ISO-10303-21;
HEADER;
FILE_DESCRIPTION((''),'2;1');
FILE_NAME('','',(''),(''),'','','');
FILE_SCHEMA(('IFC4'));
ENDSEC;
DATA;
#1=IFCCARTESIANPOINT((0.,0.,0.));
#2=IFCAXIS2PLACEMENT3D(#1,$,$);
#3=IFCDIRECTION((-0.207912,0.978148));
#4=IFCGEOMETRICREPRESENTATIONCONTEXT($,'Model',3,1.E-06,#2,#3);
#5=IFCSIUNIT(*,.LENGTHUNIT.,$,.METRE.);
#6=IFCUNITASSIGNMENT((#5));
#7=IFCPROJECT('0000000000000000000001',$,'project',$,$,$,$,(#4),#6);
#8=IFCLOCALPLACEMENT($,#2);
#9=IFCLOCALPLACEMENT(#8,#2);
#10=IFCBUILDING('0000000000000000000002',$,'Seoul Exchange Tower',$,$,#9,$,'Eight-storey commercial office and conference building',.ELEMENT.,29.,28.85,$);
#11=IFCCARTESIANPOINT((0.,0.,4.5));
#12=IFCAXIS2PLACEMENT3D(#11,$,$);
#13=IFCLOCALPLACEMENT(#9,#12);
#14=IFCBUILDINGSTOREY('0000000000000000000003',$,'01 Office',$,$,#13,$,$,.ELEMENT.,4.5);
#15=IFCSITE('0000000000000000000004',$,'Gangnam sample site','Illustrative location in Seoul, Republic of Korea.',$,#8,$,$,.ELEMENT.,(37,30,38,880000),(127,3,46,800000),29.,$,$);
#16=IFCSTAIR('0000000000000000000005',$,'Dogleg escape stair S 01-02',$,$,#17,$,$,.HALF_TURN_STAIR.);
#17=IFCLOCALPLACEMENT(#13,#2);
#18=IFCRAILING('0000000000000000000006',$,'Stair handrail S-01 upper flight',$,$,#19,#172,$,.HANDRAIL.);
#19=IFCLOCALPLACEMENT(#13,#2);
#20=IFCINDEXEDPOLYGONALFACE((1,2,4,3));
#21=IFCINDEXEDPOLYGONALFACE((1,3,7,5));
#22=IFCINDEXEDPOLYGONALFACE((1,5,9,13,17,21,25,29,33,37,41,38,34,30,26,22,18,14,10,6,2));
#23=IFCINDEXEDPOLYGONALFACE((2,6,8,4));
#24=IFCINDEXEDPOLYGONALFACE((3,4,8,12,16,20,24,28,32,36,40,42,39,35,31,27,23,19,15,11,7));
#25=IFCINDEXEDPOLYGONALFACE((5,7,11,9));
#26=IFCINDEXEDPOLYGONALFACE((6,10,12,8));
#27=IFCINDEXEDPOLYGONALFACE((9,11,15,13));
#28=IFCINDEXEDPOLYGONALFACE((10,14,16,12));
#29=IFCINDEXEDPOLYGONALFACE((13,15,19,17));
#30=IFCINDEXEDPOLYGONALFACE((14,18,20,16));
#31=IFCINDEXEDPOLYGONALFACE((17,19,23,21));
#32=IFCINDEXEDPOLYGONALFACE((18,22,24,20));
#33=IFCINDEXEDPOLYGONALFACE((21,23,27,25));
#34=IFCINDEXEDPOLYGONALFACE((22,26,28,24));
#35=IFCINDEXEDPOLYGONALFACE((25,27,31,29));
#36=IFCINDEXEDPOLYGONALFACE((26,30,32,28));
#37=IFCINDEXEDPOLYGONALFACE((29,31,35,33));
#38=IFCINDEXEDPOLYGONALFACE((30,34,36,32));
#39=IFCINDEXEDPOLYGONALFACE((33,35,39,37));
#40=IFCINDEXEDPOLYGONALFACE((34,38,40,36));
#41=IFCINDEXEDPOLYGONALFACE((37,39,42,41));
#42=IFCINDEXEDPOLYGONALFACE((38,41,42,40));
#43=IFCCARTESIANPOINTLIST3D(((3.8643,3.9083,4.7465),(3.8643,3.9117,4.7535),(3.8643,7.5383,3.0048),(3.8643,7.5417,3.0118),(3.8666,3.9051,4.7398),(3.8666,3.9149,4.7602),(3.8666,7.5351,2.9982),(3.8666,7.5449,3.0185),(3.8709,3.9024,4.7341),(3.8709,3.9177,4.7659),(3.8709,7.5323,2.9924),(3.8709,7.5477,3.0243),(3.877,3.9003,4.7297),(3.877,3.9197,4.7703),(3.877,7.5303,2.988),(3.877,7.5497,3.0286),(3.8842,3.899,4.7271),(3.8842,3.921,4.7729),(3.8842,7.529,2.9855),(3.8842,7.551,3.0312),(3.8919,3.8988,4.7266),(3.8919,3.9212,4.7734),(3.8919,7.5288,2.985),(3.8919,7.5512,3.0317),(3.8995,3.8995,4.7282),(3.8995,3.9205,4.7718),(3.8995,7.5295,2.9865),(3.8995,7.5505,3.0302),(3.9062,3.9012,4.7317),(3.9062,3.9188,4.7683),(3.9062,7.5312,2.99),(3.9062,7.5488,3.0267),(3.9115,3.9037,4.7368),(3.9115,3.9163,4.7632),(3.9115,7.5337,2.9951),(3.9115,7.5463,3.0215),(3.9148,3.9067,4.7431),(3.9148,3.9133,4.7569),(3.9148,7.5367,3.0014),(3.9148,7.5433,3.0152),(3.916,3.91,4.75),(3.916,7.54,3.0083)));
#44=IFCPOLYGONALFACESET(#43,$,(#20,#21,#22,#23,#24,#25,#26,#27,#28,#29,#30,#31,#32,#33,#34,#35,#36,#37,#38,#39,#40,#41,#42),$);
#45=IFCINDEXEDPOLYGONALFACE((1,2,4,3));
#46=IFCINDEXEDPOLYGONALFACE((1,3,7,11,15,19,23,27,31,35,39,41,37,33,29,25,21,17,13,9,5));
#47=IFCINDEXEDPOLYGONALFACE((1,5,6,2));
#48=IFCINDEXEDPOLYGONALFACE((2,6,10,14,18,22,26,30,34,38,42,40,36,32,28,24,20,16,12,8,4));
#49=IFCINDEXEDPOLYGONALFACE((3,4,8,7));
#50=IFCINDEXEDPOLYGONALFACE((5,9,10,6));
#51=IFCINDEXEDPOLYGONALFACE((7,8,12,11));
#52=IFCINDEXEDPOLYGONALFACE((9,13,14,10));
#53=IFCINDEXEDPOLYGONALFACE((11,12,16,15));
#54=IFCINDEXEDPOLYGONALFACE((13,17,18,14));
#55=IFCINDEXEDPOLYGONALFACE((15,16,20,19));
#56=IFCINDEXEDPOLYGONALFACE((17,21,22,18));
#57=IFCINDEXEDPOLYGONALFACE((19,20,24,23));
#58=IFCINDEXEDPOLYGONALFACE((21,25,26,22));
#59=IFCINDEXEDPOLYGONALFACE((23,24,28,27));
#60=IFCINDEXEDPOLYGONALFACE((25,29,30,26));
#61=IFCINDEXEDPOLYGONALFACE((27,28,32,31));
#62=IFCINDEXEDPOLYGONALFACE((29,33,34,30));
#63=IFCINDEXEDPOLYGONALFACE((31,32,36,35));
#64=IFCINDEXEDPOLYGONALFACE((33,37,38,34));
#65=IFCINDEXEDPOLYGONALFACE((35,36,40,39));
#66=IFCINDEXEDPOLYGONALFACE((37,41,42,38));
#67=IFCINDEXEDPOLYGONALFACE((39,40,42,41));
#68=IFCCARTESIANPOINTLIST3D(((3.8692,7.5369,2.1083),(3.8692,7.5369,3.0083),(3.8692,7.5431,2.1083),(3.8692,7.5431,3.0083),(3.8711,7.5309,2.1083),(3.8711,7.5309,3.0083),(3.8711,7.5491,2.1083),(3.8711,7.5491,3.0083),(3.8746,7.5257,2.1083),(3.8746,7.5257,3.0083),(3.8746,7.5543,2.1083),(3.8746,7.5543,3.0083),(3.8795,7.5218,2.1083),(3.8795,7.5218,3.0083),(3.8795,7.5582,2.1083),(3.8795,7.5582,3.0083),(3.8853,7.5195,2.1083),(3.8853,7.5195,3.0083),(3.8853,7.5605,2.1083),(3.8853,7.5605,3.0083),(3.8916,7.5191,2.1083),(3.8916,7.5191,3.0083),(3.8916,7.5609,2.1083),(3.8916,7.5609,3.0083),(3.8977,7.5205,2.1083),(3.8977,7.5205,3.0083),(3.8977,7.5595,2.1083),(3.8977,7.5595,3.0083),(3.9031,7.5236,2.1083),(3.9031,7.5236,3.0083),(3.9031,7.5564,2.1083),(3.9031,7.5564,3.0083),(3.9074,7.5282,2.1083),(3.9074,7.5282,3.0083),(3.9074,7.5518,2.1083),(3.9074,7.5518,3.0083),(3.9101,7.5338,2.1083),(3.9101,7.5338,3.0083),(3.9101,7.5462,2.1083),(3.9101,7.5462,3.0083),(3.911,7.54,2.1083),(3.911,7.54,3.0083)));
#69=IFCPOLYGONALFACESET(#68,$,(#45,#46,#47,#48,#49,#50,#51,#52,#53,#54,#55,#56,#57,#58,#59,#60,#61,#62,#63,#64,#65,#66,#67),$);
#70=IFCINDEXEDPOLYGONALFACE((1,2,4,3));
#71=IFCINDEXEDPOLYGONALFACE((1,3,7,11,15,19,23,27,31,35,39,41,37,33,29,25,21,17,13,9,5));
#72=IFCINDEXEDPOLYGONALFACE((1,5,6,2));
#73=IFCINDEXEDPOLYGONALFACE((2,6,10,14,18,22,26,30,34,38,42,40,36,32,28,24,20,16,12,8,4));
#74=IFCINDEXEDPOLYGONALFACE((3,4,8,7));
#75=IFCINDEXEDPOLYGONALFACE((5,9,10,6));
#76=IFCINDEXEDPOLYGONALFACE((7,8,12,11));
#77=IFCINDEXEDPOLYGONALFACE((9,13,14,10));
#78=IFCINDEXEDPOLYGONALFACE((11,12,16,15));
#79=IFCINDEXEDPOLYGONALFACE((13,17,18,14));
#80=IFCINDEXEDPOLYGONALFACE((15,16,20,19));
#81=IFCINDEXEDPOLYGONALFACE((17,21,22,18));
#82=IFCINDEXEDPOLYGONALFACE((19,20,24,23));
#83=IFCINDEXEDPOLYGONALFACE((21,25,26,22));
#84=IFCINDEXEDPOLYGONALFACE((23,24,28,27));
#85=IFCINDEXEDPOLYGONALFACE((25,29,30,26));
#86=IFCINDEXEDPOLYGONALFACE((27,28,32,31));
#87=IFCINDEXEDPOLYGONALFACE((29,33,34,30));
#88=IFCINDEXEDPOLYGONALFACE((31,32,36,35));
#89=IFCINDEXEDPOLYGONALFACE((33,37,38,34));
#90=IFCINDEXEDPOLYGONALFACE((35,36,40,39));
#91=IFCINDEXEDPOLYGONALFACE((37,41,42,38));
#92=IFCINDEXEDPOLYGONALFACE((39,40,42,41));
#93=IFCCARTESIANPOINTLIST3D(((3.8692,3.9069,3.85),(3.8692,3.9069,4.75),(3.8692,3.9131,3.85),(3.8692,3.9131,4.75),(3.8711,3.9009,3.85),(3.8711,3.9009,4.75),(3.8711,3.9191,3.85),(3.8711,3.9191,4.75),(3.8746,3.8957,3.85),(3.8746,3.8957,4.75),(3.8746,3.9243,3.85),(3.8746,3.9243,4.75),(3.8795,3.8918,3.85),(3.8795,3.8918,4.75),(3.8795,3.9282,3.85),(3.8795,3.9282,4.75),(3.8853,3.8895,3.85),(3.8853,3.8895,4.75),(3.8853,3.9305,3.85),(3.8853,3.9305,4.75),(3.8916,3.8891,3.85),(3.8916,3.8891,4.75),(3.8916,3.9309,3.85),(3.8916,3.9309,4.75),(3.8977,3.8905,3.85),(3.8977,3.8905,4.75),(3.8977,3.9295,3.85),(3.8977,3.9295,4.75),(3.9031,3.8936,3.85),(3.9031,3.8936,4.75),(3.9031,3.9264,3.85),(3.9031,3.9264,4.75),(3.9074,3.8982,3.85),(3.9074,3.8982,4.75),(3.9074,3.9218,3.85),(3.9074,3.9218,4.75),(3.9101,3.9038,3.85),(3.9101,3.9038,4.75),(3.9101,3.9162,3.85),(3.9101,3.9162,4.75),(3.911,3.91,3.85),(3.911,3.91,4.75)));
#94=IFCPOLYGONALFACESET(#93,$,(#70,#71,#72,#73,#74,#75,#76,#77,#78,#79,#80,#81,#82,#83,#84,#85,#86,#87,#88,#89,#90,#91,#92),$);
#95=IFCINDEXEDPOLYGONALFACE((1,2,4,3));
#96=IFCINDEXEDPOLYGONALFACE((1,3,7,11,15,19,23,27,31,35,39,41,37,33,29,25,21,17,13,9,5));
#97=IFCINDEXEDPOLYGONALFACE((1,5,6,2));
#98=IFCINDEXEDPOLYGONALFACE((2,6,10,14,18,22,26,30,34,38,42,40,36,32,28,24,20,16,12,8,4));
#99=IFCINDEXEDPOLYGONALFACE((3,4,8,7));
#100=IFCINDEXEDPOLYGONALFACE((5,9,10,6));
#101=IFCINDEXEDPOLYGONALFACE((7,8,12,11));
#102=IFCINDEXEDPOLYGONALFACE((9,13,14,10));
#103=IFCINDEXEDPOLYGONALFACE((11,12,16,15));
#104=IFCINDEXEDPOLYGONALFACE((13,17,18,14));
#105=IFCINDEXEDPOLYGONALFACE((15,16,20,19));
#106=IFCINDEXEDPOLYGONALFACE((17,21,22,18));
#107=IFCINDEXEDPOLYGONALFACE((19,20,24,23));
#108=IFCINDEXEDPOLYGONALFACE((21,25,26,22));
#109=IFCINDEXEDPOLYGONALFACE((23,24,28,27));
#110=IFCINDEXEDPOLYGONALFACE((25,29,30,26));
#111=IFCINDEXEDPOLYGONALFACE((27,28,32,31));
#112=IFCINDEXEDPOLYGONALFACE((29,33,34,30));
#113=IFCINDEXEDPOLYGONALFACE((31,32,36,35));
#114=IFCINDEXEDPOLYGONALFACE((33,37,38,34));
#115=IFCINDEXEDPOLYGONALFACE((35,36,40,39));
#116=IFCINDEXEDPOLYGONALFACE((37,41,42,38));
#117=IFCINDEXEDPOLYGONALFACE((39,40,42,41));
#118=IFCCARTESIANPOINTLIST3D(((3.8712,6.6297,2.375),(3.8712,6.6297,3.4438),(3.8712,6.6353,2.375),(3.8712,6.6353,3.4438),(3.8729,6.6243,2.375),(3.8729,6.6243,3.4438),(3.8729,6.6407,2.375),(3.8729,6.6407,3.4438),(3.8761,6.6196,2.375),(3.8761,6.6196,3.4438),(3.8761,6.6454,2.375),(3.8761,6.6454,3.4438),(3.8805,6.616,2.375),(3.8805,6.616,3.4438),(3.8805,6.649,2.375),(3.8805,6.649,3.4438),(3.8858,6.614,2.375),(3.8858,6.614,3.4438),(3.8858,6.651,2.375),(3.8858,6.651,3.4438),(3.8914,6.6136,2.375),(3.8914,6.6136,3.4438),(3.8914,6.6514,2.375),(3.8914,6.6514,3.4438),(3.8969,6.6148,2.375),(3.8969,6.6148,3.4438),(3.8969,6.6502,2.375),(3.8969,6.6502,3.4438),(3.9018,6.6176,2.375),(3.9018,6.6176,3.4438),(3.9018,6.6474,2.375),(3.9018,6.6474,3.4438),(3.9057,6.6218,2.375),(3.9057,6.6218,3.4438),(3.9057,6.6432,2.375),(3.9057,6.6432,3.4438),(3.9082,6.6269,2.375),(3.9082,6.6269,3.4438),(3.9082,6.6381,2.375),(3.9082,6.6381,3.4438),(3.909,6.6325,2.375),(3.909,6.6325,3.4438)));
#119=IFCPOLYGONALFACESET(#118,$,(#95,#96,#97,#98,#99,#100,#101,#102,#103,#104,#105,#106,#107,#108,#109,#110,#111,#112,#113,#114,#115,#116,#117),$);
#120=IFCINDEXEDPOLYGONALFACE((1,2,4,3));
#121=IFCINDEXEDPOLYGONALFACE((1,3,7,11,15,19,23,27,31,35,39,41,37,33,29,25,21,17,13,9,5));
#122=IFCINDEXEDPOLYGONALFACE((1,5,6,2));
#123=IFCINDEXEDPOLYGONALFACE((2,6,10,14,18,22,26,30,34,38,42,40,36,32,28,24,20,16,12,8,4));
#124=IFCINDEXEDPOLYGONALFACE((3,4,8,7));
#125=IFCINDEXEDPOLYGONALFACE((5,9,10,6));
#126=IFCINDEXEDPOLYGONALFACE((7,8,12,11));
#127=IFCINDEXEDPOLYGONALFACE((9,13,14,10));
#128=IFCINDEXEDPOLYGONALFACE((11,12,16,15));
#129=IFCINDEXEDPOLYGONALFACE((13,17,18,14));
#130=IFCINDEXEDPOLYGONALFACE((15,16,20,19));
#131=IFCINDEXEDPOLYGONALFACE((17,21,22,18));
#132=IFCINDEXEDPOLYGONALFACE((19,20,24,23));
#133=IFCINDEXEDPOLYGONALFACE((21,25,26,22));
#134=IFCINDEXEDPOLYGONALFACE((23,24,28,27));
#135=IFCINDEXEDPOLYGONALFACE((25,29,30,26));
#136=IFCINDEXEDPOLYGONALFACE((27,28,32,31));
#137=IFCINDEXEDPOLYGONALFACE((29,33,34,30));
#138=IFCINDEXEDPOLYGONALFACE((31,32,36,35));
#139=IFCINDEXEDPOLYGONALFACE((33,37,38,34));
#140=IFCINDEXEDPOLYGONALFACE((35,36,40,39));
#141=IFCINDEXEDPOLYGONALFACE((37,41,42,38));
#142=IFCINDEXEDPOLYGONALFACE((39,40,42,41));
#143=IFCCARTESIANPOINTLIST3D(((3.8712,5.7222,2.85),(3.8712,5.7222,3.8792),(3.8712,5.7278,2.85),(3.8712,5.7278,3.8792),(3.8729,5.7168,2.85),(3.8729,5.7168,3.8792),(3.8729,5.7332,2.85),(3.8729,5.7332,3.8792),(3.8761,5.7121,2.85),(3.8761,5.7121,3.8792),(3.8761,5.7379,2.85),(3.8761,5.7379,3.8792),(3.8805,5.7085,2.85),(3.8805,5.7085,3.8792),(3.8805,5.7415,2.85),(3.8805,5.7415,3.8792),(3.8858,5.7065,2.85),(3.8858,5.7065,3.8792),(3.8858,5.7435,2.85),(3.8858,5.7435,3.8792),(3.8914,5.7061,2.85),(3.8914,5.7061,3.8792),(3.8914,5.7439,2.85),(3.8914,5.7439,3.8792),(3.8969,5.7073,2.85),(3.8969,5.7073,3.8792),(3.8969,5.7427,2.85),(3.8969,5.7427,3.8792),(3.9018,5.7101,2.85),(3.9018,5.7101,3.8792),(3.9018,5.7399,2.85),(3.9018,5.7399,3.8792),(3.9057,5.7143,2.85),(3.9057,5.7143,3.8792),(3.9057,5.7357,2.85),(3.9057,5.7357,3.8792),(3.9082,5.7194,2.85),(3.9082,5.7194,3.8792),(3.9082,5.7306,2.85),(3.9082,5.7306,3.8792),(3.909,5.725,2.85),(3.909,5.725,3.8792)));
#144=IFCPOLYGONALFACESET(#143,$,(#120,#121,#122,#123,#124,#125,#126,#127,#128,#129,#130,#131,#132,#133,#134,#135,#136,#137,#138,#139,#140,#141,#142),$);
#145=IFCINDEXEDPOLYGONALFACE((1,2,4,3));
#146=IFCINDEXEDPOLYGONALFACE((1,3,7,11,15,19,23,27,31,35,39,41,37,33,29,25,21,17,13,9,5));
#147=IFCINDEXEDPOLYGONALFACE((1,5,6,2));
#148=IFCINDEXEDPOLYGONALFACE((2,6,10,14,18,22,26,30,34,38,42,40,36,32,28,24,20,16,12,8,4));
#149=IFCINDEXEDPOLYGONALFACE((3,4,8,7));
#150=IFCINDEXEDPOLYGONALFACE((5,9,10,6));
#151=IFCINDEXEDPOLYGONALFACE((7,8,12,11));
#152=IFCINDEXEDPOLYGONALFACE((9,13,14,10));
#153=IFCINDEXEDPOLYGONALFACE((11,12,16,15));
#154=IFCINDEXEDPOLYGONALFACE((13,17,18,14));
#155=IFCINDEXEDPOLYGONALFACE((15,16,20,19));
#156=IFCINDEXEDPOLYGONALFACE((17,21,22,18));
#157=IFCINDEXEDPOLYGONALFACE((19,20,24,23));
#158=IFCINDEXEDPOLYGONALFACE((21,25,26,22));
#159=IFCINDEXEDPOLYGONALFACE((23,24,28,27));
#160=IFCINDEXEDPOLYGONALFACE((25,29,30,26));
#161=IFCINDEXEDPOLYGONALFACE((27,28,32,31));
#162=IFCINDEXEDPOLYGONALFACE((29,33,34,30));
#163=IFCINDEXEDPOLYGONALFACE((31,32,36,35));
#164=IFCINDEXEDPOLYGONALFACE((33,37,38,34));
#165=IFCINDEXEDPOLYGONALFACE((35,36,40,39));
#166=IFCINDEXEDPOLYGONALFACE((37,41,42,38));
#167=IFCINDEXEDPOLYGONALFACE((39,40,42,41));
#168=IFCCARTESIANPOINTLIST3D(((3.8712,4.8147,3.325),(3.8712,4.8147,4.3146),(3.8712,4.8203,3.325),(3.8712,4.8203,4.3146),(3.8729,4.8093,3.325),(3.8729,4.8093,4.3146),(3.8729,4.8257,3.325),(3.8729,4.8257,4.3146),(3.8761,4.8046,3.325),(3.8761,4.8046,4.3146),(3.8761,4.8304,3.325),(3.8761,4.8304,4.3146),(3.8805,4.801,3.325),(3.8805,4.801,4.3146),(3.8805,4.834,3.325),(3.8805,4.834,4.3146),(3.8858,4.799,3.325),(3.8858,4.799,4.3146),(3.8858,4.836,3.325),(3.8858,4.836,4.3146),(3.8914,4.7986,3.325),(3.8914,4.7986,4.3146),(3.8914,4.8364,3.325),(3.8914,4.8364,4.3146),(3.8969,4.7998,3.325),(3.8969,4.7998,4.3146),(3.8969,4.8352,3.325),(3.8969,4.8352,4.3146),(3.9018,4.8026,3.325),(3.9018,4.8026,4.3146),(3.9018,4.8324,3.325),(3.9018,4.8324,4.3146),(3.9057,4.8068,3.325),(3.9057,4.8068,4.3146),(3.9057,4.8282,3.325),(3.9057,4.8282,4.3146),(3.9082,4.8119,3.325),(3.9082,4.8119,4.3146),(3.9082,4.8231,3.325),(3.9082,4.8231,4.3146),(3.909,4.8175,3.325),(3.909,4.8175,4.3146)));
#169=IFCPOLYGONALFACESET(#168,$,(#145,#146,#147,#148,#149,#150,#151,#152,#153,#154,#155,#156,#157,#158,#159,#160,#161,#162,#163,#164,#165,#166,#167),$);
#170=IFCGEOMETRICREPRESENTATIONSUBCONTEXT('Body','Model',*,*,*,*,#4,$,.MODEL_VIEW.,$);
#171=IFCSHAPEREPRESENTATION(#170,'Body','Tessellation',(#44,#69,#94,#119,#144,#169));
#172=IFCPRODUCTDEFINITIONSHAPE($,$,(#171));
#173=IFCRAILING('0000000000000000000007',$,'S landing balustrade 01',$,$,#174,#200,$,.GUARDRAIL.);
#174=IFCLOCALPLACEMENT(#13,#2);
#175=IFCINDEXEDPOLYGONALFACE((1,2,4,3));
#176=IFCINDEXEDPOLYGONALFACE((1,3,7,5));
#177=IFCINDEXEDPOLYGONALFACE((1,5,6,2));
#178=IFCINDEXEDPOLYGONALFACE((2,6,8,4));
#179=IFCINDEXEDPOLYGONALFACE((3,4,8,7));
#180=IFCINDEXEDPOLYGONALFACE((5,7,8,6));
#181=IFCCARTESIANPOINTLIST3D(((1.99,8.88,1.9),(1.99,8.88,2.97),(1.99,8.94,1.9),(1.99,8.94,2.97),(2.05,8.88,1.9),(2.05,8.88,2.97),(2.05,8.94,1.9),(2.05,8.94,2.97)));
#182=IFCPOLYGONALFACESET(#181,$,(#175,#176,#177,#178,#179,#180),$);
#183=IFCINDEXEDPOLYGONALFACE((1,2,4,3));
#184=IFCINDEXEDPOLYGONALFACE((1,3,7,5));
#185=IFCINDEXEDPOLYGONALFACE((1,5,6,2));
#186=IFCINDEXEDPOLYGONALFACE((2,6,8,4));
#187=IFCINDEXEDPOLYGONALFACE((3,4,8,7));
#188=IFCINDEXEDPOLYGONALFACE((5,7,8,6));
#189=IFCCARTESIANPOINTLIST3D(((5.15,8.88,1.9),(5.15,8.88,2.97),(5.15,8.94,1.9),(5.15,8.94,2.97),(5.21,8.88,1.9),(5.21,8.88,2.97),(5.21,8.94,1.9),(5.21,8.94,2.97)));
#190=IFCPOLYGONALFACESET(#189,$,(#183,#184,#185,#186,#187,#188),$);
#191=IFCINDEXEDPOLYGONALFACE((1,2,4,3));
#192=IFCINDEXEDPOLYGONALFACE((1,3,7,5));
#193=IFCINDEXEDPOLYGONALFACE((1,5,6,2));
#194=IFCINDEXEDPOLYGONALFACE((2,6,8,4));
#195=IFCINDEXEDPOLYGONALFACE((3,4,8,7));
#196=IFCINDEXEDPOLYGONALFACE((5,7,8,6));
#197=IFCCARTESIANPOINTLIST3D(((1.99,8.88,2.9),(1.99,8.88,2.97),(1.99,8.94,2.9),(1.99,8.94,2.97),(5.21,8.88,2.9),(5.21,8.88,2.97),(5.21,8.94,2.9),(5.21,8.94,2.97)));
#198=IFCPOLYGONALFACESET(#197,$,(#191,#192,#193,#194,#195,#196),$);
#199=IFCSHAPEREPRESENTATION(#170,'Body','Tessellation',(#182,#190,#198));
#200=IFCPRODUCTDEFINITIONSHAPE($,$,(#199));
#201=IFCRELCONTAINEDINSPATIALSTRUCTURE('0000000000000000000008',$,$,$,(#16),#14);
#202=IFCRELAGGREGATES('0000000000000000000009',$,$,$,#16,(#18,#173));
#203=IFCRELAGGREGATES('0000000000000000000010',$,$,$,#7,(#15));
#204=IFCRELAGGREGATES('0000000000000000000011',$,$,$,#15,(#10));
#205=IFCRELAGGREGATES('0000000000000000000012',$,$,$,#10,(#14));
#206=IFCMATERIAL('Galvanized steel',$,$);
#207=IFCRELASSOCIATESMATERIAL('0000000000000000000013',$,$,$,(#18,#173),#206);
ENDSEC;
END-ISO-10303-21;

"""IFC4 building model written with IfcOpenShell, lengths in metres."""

from ifc_helpers import new_model, si_unit, direction, frame, frame_2d, origin, place, context, subcontext, project, spatial, rectangle, circle, extrude, material, element, aggregate, save


model = new_model("IFC4")

# Units and contexts
model_context = context("Model", 3, precision=1e-06, world=origin(), true_north=direction((-0.207912, 0.978148)))
body_context = subcontext(model_context, "Body", "Model", "MODEL_VIEW")
ifc_project = project(units=[si_unit("LENGTHUNIT", "METRE")], contexts=[model_context])

# Site, building, storey
site_placement = place(None, origin())
site = spatial("IfcSite", under=ifc_project, at=site_placement, Name="Gangnam sample site", Description="Illustrative location in Seoul, Republic of Korea.", CompositionType="ELEMENT", RefLatitude=(37, 30, 38, 880000), RefLongitude=(127, 3, 46, 800000), RefElevation=29.0)
building_placement = place(site_placement, origin())
building = spatial("IfcBuilding", under=site, at=building_placement, Name="Seoul Exchange Tower", LongName="Eight-storey commercial office and conference building", CompositionType="ELEMENT", ElevationOfRefHeight=29.0, ElevationOfTerrain=28.85)
storey_placement = place(building_placement, frame((0.0, 0.0, 4.5)))
storey = spatial("IfcBuildingStorey", under=building, at=storey_placement, Name="01 Office", CompositionType="ELEMENT", Elevation=4.5)

# Shared definitions
placement_1 = place(storey_placement, origin())

# Stair
placement_2 = place(placement_1, origin())
stair_1 = element("IfcStair", 1, at=placement_1, inside=storey, Name="Dogleg escape stair S 01-02", PredefinedType="HALF_TURN_STAIR")

# Railings
ifc_material_1 = material(Name="Galvanized steel")
railing_1 = element("IfcRailing", 2, at=placement_2, material=ifc_material_1, Name="Stair handrail S-01 upper flight", PredefinedType="HANDRAIL", context=body_context, shape_type="SweptSolid", body=[
    extrude(circle(Radius=0.026), frame((3.89, 7.54, 3.0083), z_axis=(0.0, -0.901594, 0.432583), x_axis=(1.0, 0.0, 0.0)), (0.0, 0.0, 1.0), 4.0262),
    extrude(circle(Radius=0.021), frame((3.89, 7.54, 2.1083), z_axis=(0.0, 0.0, 1.0), x_axis=(1.0, 0.0, 0.0)), (0.0, 0.0, 1.0), 0.9),
    extrude(circle(Radius=0.021), frame((3.89, 3.91, 3.85), z_axis=(0.0, 0.0, 1.0), x_axis=(1.0, 0.0, 0.0)), (0.0, 0.0, 1.0), 0.9),
    extrude(circle(Radius=0.019), frame((3.89, 6.6325, 2.375), z_axis=(0.0, 0.0, 1.0), x_axis=(1.0, 0.0, 0.0)), (0.0, 0.0, 1.0), 1.0688),
    extrude(circle(Radius=0.019), frame((3.89, 5.725, 2.85), z_axis=(0.0, 0.0, 1.0), x_axis=(1.0, 0.0, 0.0)), (0.0, 0.0, 1.0), 1.0292),
    extrude(circle(Radius=0.019), frame((3.89, 4.8175, 3.325), z_axis=(0.0, 0.0, 1.0), x_axis=(1.0, 0.0, 0.0)), (0.0, 0.0, 1.0), 0.9896),
])
railing_2 = element("IfcRailing", 3, at=placement_2, material=ifc_material_1, Name="S landing balustrade 01", PredefinedType="GUARDRAIL", context=body_context, shape_type="SweptSolid", body=[
    extrude(rectangle(XDim=0.06, YDim=0.06, at=frame_2d((0.03, 0.03))), frame((1.99, 8.88, 1.9)), (0.0, 0.0, 1.0), 1.07),
    extrude(rectangle(XDim=0.06, YDim=0.06, at=frame_2d((0.03, 0.03))), frame((5.15, 8.88, 1.9)), (0.0, 0.0, 1.0), 1.07),
    extrude(rectangle(XDim=3.22, YDim=0.06, at=frame_2d((1.61, 0.03))), frame((1.99, 8.88, 2.9)), (0.0, 0.0, 1.0), 0.07),
])
aggregate(stair_1, [railing_1, railing_2])

save(model, "model.ifc")
